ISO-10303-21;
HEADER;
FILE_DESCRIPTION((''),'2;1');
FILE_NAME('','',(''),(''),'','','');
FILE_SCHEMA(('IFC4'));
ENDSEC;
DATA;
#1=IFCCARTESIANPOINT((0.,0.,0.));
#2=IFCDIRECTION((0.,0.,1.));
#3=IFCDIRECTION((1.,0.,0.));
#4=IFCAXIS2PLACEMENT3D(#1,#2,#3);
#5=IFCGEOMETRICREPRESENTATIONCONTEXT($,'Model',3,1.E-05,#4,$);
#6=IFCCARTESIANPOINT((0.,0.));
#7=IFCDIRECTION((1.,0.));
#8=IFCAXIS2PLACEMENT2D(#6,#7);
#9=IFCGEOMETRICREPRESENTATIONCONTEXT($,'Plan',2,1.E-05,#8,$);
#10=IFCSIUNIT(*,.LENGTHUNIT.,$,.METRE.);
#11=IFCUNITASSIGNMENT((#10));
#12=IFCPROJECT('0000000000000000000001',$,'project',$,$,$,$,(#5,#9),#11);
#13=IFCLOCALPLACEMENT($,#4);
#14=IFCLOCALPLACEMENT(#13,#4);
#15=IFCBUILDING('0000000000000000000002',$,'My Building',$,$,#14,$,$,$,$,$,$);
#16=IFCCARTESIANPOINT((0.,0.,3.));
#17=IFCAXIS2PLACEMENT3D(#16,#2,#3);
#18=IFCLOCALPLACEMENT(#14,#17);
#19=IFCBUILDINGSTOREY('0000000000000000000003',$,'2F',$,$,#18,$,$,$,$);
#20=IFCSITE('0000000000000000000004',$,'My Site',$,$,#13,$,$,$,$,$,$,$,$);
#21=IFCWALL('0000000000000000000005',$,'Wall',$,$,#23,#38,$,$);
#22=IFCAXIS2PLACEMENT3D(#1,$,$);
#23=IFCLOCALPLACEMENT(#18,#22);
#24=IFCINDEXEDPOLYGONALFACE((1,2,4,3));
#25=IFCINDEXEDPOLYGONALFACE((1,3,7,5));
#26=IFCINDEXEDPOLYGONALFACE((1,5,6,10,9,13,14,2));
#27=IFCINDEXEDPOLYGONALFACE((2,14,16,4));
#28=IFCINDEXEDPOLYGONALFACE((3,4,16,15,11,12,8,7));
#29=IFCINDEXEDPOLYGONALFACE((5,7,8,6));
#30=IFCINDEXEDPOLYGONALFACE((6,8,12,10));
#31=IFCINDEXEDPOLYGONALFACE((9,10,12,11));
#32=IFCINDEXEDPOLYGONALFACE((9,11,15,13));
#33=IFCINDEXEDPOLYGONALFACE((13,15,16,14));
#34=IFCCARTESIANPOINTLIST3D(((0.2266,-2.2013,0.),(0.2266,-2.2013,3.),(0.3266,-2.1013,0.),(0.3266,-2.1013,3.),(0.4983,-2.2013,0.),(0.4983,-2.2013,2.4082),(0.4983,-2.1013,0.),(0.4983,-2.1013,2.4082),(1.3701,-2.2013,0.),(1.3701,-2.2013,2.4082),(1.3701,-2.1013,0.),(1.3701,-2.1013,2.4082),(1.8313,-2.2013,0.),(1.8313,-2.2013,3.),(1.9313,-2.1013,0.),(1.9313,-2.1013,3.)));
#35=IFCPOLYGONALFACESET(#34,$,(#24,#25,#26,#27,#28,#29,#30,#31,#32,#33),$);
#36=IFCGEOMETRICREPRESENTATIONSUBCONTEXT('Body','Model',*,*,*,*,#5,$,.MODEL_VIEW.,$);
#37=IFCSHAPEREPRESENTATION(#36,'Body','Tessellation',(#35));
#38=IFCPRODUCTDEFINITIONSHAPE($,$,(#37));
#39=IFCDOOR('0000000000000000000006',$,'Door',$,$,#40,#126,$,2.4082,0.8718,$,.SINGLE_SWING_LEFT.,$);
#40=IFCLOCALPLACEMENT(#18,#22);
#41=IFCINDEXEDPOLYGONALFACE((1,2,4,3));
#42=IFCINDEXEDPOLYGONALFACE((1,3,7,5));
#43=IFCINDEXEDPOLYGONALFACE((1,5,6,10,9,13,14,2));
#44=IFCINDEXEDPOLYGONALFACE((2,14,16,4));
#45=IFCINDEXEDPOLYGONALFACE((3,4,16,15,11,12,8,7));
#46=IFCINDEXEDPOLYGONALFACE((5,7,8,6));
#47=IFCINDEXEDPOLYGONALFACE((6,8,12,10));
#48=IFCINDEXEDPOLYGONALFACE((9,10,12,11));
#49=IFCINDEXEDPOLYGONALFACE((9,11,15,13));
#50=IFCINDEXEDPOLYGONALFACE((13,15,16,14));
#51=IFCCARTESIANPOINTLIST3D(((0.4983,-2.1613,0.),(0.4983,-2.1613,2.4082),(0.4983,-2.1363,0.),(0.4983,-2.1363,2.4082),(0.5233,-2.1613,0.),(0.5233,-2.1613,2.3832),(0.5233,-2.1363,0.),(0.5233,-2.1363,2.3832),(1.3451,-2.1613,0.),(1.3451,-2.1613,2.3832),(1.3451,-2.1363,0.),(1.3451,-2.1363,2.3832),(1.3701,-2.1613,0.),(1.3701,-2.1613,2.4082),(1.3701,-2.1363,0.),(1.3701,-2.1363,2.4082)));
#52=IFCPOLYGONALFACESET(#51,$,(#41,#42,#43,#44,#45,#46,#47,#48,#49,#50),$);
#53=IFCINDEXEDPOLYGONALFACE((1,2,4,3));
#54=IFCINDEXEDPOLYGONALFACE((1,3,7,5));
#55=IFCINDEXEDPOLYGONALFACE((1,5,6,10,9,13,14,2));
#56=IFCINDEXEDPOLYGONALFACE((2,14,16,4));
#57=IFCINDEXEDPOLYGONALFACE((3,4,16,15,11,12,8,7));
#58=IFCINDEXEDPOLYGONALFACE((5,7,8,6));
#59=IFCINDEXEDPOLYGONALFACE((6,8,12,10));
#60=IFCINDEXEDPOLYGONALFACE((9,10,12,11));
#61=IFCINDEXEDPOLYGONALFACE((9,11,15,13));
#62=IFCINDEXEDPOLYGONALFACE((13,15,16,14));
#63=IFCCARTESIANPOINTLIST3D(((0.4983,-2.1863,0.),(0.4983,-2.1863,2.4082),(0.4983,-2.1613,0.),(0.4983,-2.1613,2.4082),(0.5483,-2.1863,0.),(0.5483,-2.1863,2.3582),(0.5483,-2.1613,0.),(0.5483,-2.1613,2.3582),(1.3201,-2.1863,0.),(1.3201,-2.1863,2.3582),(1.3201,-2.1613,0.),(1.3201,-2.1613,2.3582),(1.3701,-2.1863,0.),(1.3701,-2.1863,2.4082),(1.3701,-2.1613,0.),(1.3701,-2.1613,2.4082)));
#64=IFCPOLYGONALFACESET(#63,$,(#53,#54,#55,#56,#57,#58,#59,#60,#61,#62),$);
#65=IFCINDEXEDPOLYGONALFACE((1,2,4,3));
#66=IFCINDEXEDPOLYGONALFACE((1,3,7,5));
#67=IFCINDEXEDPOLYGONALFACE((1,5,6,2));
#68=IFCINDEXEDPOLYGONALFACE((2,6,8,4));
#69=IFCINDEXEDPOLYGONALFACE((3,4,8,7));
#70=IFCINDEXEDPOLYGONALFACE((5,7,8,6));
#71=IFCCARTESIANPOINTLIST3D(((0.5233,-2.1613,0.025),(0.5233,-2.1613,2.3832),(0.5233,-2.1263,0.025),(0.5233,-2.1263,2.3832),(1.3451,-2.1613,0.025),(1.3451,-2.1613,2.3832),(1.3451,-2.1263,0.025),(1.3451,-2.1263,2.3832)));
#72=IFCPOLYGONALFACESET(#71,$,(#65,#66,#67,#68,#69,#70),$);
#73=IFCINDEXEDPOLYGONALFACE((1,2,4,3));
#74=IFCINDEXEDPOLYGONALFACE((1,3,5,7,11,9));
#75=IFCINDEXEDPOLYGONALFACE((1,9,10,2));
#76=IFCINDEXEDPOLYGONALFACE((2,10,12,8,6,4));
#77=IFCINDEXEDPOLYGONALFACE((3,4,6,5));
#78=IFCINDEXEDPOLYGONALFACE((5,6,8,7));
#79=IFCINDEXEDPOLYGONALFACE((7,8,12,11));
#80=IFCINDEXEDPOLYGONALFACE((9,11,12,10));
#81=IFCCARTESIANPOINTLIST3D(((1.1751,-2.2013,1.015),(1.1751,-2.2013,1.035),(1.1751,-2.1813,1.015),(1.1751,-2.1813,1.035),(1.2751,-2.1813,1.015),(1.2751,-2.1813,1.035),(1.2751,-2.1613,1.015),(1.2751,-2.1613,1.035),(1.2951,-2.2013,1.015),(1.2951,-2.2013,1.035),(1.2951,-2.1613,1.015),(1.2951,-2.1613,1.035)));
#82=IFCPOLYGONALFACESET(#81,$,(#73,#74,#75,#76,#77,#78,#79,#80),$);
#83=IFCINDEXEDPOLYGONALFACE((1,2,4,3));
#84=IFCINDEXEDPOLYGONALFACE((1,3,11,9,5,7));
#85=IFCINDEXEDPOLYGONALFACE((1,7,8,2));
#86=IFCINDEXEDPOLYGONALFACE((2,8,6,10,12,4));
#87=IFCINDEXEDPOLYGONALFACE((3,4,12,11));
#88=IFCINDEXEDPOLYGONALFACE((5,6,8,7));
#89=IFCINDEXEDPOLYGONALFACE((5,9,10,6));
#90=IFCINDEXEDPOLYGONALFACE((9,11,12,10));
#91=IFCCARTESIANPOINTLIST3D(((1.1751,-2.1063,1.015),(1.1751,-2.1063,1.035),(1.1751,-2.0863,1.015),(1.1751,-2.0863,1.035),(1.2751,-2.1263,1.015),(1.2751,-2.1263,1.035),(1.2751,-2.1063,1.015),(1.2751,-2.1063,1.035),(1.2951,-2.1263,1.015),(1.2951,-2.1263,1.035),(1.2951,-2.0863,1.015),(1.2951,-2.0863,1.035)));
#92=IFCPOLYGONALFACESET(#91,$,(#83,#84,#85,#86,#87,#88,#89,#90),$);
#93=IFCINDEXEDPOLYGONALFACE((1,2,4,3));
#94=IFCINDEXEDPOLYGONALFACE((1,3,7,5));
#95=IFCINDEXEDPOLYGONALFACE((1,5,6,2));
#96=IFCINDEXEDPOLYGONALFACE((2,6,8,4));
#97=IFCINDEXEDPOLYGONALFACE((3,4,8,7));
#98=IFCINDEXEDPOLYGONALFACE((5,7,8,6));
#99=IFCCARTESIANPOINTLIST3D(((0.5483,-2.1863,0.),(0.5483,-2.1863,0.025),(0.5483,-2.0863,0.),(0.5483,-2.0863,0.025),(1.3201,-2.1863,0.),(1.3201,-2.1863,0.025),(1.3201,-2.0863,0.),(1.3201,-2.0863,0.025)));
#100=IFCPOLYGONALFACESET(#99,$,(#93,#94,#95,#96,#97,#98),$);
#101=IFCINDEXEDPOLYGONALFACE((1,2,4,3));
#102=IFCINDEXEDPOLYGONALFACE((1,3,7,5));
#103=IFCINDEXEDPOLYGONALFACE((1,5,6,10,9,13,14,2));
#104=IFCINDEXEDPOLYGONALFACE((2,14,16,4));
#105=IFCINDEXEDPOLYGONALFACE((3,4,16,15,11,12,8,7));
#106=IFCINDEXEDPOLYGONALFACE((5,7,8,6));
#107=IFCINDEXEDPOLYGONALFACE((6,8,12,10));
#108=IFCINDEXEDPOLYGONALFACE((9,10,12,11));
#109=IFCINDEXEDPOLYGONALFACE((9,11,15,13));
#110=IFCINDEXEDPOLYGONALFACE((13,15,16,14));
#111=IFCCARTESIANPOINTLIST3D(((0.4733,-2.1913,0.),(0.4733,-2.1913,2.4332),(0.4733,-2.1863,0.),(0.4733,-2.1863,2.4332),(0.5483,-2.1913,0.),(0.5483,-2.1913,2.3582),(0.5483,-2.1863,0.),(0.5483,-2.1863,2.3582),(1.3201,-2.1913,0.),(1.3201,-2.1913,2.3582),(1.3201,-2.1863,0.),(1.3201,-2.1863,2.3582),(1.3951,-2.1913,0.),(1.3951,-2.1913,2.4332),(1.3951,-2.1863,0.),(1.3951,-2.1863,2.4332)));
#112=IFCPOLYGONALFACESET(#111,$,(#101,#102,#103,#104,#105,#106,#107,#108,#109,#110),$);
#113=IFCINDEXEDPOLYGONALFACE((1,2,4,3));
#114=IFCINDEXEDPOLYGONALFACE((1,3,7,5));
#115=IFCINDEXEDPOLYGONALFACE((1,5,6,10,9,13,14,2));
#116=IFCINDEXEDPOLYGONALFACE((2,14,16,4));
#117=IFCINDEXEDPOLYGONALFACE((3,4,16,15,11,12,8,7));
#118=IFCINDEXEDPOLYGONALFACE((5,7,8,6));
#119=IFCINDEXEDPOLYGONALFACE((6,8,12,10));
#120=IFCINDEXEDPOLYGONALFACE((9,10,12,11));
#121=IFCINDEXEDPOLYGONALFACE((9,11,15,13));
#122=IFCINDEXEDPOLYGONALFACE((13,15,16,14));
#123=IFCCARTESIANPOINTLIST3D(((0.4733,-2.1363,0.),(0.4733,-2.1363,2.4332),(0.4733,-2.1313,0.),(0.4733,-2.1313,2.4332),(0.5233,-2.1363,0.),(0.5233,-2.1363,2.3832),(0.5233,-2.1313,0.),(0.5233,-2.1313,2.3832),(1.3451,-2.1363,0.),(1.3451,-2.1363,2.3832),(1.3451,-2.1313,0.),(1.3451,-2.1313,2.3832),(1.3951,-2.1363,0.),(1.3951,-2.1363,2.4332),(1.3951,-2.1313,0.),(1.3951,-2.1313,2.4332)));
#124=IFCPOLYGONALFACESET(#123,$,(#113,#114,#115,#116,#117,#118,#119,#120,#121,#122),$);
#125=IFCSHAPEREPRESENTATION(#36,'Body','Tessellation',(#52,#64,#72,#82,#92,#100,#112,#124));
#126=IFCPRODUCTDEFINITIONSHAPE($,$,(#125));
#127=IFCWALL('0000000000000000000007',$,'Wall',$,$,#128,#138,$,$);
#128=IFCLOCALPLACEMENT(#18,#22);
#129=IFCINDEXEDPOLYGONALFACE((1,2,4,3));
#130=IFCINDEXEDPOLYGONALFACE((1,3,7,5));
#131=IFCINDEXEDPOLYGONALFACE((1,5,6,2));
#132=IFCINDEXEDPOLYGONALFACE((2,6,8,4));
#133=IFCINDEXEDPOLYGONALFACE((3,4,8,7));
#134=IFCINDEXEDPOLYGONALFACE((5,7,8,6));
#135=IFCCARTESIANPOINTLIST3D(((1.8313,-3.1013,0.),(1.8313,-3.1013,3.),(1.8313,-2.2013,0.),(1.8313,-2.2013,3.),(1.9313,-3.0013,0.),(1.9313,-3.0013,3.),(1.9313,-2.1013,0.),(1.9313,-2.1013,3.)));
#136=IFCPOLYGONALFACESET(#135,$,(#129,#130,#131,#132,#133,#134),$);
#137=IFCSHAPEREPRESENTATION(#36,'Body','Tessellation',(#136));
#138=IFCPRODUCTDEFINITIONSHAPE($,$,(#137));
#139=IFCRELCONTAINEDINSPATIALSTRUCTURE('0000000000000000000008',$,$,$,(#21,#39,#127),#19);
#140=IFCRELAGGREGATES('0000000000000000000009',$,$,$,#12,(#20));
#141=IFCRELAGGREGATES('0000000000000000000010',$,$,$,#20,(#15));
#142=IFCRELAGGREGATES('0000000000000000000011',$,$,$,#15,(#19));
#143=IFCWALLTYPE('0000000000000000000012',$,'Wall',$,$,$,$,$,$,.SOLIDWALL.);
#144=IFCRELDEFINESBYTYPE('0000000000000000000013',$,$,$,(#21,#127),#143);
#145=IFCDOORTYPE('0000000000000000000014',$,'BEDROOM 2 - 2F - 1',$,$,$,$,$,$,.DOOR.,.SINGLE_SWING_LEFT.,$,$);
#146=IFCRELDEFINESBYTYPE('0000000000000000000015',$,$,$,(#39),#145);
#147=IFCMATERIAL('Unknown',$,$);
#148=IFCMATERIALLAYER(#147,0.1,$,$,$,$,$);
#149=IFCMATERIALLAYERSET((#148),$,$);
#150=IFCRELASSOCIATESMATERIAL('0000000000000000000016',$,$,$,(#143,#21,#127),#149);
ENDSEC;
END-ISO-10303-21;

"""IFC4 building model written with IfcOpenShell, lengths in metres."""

from ifc_helpers import new_model, entity, si_unit, frame, origin_with_axes, origin_2d_with_axis, place, context, subcontext, project, spatial, line, indexed_curve, outline, extrude, shape, source, transform, mapped, material, layer, layer_set, layer_usage, type_object, type_shapes, element, fill, save


model = new_model("IFC4")

# Units and contexts
model_context = context("Model", 3, precision=1e-05, world=origin_with_axes())
plan_context = context("Plan", 2, precision=1e-05, world=origin_2d_with_axis())
body_context_1 = subcontext(model_context, "Body", "Model", "MODEL_VIEW")
body_context_2 = subcontext(plan_context, "Body", "Plan", "PLAN_VIEW")
ifc_project = project(units=[si_unit("LENGTHUNIT", "METRE")], contexts=[model_context, plan_context])

# Site, building, storey
site_placement = place(None, origin_with_axes())
site = spatial("IfcSite", under=ifc_project, at=site_placement, Name="My Site")
building_placement = place(site_placement, origin_with_axes())
building = spatial("IfcBuilding", under=site, at=building_placement, Name="My Building")
storey_placement = place(building_placement, frame((0.0, 0.0, 3.0), z_axis=(0.0, 0.0, 1.0), x_axis=(1.0, 0.0, 0.0)))
storey = spatial("IfcBuildingStorey", under=building, at=storey_placement, Name="2F")

# Shared definitions
ifc_material = material(Name="Unknown")

# Shared definitions
ifc_layer_1 = layer(ifc_material, 0.1)
ifc_layer_set_1 = layer_set([ifc_layer_1])
wall_type = type_object("IfcWallType", Name="Wall", PredefinedType="SOLIDWALL", material=ifc_layer_set_1)

# Wall, opening, door
ifc_layer_usage_1 = layer_usage(ifc_layer_set_1, "AXIS2", "POSITIVE", 0.0)
wall_1_placement = place(storey_placement, frame((0.2266, -2.2013, 0.0), z_axis=(0.0, 0.0, 1.0), x_axis=(1.0, 0.0, 0.0)))
wall_1 = element("IfcWall", 1, at=wall_1_placement, inside=storey, type_object=wall_type, material=ifc_layer_usage_1, Name="Wall", context=body_context_1, shape_type="SweptSolid", body=[
    extrude(outline(indexed_curve([(0.0, 0.0), (0.1, 0.1), (1.7047, 0.1), (1.6047, 0.0)], segments=[line(1, 2, 3, 4, 1)])), origin_with_axes(), (0.0, 0.0, 1.0), 3.0),
])
shared_shape_1 = source(origin_with_axes(), body_context_1, "Body", "SweptSolid", [
    extrude(outline(indexed_curve([(0.0, 0.0), (0.8718, 0.0), (0.8718, 2.4082), (0.0, 2.4082)], segments=[line(1, 2, 3, 4, 1)])), frame((0.0, -0.6, 0.0), z_axis=(0.0, -1.0, 0.0), x_axis=(1.0, 0.0, 0.0)), (0.0, 0.0, -1.0), 1.2),
])
opening_1_placement = place(wall_1_placement, frame((0.2717, 0.015, 0.0), z_axis=(0.0, 0.0, 1.0), x_axis=(1.0, 0.0, 0.0)))
opening_1 = element("IfcOpeningElement", 2, at=opening_1_placement, cuts=wall_1, PredefinedType="OPENING", context=body_context_1, shape_type="MappedRepresentation", body=[
    mapped(shared_shape_1, transform((0.0, 0.0, 0.0), x_axis=(1.0, 0.0, 0.0), y_axis=(0.0, 1.0, 0.0), z_axis=(0.0, 0.0, 1.0), scale=1.0)),
])
door_type_1 = type_object("IfcDoorType", Name="BEDROOM 2 - 2F - 1", OperationType="SINGLE_SWING_LEFT", PredefinedType="DOOR")
shared_shape_2 = source(origin_with_axes(), body_context_1, "Body", "SweptSolid", [
    extrude(outline(indexed_curve([(0.0, 0.0), (0.0, 2.4082), (0.8718, 2.4082), (0.8718, 0.0), (0.8468, 0.0), (0.8468, 2.3832), (0.025, 2.3832), (0.025, 0.0)], segments=[line(1, 2, 3, 4, 5, 6, 7, 8, 1)])), frame((0.0, 0.025, 0.0), z_axis=(0.0, -1.0, 0.0), x_axis=(1.0, 0.0, 0.0)), (0.0, 0.0, -1.0), 0.025),
    extrude(outline(indexed_curve([(0.0, 0.0), (0.0, 2.4082), (0.8718, 2.4082), (0.8718, 0.0), (0.8218, 0.0), (0.8218, 2.3582), (0.05, 2.3582), (0.05, 0.0)], segments=[line(1, 2, 3, 4, 5, 6, 7, 8, 1)])), frame((0.0, 0.0, 0.0), z_axis=(0.0, -1.0, 0.0), x_axis=(1.0, 0.0, 0.0)), (0.0, 0.0, -1.0), 0.025),
    extrude(outline(indexed_curve([(0.0, 0.0), (0.8218, 0.0), (0.8218, 0.035), (0.0, 0.035)], segments=[line(1, 2, 3, 4, 1)])), frame((0.025, 0.025, 0.025), z_axis=(0.0, 0.0, 1.0), x_axis=(1.0, 0.0, 0.0)), (0.0, 0.0, 1.0), 2.3582),
    extrude(outline(indexed_curve([(0.0, 0.0), (0.0, -0.04), (-0.12, -0.04), (-0.12, -0.02), (-0.02, -0.02), (-0.02, 0.0)], segments=[line(1, 2, 3, 4, 5, 6, 1)])), frame((0.7968, 0.025, 1.015), z_axis=(0.0, 0.0, 1.0), x_axis=(1.0, 0.0, 0.0)), (0.0, 0.0, 1.0), 0.02),
    extrude(outline(indexed_curve([(0.0, 0.0), (0.0, 0.04), (-0.12, 0.04), (-0.12, 0.02), (-0.02, 0.02), (-0.02, 0.0)], segments=[line(1, 2, 3, 4, 5, 6, 1)])), frame((0.7968, 0.06, 1.015), z_axis=(0.0, 0.0, 1.0), x_axis=(1.0, 0.0, 0.0)), (0.0, 0.0, 1.0), 0.02),
    extrude(outline(indexed_curve([(0.0, 0.0), (0.7718, 0.0), (0.7718, 0.1), (0.0, 0.1)], segments=[line(1, 2, 3, 4, 1)])), frame((0.05, 0.0, 0.0), z_axis=(0.0, 0.0, 1.0), x_axis=(1.0, 0.0, 0.0)), (0.0, 0.0, 1.0), 0.025),
    extrude(outline(indexed_curve([(0.0, 0.0), (0.0, 2.4332), (0.9218, 2.4332), (0.9218, 0.0), (0.8468, 0.0), (0.8468, 2.3582), (0.075, 2.3582), (0.075, 0.0)], segments=[line(1, 2, 3, 4, 5, 6, 7, 8, 1)])), frame((-0.025, -0.005, 0.0), z_axis=(0.0, -1.0, 0.0), x_axis=(1.0, 0.0, 0.0)), (0.0, 0.0, -1.0), 0.005),
    extrude(outline(indexed_curve([(0.0, 0.0), (0.0, 2.4332), (0.9218, 2.4332), (0.9218, 0.0), (0.8718, 0.0), (0.8718, 2.3832), (0.05, 2.3832), (0.05, 0.0)], segments=[line(1, 2, 3, 4, 5, 6, 7, 8, 1)])), frame((-0.025, 0.05, 0.0), z_axis=(0.0, -1.0, 0.0), x_axis=(1.0, 0.0, 0.0)), (0.0, 0.0, -1.0), 0.005),
])
shared_shape_3 = source(origin_with_axes(), body_context_2, "Body", "Curve2D", [
    entity("IfcIndexedPolyCurve", entity("IfcCartesianPointList2D", [[0.0, 0.0], [0.0, 0.05], [0.025, 0.05], [0.025, 0.025], [0.05, 0.025], [0.05, 0.0]]), [entity("IfcLineIndex", [1, 2, 3, 4, 5, 6, 1])]),
    entity("IfcIndexedPolyCurve", entity("IfcCartesianPointList2D", [[0.8718, 0.0], [0.8718, 0.05], [0.8468, 0.05], [0.8468, 0.025], [0.8218, 0.025], [0.8218, 0.0]]), [entity("IfcLineIndex", [1, 2, 3, 4, 5, 6, 1])]),
    entity("IfcTrimmedCurve", entity("IfcEllipse", entity("IfcAxis2Placement2D", entity("IfcCartesianPoint", [0.06, 0.05]), entity("IfcDirection", [1.0, 0.0])), 0.7868, 0.8218), [entity("IfcCartesianPoint", [0.8468, 0.05])], [entity("IfcCartesianPoint", [0.06, 0.8718])], True, "CARTESIAN"),
    entity("IfcIndexedPolyCurve", entity("IfcCartesianPointList2D", [[0.025, 0.05], [0.06, 0.05], [0.06, 0.8718], [0.025, 0.8718]]), [entity("IfcLineIndex", [1, 2, 3, 4, 1])]),
])
type_shapes(door_type_1, [shared_shape_2, shared_shape_3])
door_1_placement = place(opening_1_placement, frame((0.0, 0.0, 0.0), z_axis=(0.0, 0.0, 1.0), x_axis=(1.0, 0.0, 0.0)))
door_1 = element("IfcDoor", 3, at=door_1_placement, inside=storey, type_object=door_type_1, Name="Door", OperationType="SINGLE_SWING_LEFT", OverallHeight=2.4082, OverallWidth=0.8718, shapes=[
    shape(body_context_1, "Body", "MappedRepresentation", [mapped(shared_shape_2, transform((0.0, 0.0, 0.0), x_axis=(1.0, 0.0, 0.0), y_axis=(0.0, 1.0, 0.0), z_axis=(0.0, 0.0, 1.0), scale=1.0))]),
    shape(body_context_2, "Body", "MappedRepresentation", [mapped(shared_shape_3, transform((0.0, 0.0, 0.0), x_axis=(1.0, 0.0, 0.0), y_axis=(0.0, 1.0, 0.0), z_axis=(0.0, 0.0, 1.0), scale=1.0))]),
])
fill(opening_1, door_1)

# Wall
ifc_layer_usage_2 = layer_usage(ifc_layer_set_1, "AXIS2", "POSITIVE", 0.0)
wall_2_placement = place(storey_placement, frame((1.8313, -2.2013, 0.0), z_axis=(0.0, 0.0, 1.0), x_axis=(0.0, -1.0, 0.0)))
element("IfcWall", 4, at=wall_2_placement, inside=storey, type_object=wall_type, material=ifc_layer_usage_2, Name="Wall", context=body_context_1, shape_type="SweptSolid", body=[
    extrude(outline(indexed_curve([(0.0, 0.0), (-0.1, 0.1), (0.8, 0.1), (0.9, 0.0)], segments=[line(1, 2, 3, 4, 1)])), origin_with_axes(), (0.0, 0.0, 1.0), 3.0),
])

save(model, "model.ifc")
